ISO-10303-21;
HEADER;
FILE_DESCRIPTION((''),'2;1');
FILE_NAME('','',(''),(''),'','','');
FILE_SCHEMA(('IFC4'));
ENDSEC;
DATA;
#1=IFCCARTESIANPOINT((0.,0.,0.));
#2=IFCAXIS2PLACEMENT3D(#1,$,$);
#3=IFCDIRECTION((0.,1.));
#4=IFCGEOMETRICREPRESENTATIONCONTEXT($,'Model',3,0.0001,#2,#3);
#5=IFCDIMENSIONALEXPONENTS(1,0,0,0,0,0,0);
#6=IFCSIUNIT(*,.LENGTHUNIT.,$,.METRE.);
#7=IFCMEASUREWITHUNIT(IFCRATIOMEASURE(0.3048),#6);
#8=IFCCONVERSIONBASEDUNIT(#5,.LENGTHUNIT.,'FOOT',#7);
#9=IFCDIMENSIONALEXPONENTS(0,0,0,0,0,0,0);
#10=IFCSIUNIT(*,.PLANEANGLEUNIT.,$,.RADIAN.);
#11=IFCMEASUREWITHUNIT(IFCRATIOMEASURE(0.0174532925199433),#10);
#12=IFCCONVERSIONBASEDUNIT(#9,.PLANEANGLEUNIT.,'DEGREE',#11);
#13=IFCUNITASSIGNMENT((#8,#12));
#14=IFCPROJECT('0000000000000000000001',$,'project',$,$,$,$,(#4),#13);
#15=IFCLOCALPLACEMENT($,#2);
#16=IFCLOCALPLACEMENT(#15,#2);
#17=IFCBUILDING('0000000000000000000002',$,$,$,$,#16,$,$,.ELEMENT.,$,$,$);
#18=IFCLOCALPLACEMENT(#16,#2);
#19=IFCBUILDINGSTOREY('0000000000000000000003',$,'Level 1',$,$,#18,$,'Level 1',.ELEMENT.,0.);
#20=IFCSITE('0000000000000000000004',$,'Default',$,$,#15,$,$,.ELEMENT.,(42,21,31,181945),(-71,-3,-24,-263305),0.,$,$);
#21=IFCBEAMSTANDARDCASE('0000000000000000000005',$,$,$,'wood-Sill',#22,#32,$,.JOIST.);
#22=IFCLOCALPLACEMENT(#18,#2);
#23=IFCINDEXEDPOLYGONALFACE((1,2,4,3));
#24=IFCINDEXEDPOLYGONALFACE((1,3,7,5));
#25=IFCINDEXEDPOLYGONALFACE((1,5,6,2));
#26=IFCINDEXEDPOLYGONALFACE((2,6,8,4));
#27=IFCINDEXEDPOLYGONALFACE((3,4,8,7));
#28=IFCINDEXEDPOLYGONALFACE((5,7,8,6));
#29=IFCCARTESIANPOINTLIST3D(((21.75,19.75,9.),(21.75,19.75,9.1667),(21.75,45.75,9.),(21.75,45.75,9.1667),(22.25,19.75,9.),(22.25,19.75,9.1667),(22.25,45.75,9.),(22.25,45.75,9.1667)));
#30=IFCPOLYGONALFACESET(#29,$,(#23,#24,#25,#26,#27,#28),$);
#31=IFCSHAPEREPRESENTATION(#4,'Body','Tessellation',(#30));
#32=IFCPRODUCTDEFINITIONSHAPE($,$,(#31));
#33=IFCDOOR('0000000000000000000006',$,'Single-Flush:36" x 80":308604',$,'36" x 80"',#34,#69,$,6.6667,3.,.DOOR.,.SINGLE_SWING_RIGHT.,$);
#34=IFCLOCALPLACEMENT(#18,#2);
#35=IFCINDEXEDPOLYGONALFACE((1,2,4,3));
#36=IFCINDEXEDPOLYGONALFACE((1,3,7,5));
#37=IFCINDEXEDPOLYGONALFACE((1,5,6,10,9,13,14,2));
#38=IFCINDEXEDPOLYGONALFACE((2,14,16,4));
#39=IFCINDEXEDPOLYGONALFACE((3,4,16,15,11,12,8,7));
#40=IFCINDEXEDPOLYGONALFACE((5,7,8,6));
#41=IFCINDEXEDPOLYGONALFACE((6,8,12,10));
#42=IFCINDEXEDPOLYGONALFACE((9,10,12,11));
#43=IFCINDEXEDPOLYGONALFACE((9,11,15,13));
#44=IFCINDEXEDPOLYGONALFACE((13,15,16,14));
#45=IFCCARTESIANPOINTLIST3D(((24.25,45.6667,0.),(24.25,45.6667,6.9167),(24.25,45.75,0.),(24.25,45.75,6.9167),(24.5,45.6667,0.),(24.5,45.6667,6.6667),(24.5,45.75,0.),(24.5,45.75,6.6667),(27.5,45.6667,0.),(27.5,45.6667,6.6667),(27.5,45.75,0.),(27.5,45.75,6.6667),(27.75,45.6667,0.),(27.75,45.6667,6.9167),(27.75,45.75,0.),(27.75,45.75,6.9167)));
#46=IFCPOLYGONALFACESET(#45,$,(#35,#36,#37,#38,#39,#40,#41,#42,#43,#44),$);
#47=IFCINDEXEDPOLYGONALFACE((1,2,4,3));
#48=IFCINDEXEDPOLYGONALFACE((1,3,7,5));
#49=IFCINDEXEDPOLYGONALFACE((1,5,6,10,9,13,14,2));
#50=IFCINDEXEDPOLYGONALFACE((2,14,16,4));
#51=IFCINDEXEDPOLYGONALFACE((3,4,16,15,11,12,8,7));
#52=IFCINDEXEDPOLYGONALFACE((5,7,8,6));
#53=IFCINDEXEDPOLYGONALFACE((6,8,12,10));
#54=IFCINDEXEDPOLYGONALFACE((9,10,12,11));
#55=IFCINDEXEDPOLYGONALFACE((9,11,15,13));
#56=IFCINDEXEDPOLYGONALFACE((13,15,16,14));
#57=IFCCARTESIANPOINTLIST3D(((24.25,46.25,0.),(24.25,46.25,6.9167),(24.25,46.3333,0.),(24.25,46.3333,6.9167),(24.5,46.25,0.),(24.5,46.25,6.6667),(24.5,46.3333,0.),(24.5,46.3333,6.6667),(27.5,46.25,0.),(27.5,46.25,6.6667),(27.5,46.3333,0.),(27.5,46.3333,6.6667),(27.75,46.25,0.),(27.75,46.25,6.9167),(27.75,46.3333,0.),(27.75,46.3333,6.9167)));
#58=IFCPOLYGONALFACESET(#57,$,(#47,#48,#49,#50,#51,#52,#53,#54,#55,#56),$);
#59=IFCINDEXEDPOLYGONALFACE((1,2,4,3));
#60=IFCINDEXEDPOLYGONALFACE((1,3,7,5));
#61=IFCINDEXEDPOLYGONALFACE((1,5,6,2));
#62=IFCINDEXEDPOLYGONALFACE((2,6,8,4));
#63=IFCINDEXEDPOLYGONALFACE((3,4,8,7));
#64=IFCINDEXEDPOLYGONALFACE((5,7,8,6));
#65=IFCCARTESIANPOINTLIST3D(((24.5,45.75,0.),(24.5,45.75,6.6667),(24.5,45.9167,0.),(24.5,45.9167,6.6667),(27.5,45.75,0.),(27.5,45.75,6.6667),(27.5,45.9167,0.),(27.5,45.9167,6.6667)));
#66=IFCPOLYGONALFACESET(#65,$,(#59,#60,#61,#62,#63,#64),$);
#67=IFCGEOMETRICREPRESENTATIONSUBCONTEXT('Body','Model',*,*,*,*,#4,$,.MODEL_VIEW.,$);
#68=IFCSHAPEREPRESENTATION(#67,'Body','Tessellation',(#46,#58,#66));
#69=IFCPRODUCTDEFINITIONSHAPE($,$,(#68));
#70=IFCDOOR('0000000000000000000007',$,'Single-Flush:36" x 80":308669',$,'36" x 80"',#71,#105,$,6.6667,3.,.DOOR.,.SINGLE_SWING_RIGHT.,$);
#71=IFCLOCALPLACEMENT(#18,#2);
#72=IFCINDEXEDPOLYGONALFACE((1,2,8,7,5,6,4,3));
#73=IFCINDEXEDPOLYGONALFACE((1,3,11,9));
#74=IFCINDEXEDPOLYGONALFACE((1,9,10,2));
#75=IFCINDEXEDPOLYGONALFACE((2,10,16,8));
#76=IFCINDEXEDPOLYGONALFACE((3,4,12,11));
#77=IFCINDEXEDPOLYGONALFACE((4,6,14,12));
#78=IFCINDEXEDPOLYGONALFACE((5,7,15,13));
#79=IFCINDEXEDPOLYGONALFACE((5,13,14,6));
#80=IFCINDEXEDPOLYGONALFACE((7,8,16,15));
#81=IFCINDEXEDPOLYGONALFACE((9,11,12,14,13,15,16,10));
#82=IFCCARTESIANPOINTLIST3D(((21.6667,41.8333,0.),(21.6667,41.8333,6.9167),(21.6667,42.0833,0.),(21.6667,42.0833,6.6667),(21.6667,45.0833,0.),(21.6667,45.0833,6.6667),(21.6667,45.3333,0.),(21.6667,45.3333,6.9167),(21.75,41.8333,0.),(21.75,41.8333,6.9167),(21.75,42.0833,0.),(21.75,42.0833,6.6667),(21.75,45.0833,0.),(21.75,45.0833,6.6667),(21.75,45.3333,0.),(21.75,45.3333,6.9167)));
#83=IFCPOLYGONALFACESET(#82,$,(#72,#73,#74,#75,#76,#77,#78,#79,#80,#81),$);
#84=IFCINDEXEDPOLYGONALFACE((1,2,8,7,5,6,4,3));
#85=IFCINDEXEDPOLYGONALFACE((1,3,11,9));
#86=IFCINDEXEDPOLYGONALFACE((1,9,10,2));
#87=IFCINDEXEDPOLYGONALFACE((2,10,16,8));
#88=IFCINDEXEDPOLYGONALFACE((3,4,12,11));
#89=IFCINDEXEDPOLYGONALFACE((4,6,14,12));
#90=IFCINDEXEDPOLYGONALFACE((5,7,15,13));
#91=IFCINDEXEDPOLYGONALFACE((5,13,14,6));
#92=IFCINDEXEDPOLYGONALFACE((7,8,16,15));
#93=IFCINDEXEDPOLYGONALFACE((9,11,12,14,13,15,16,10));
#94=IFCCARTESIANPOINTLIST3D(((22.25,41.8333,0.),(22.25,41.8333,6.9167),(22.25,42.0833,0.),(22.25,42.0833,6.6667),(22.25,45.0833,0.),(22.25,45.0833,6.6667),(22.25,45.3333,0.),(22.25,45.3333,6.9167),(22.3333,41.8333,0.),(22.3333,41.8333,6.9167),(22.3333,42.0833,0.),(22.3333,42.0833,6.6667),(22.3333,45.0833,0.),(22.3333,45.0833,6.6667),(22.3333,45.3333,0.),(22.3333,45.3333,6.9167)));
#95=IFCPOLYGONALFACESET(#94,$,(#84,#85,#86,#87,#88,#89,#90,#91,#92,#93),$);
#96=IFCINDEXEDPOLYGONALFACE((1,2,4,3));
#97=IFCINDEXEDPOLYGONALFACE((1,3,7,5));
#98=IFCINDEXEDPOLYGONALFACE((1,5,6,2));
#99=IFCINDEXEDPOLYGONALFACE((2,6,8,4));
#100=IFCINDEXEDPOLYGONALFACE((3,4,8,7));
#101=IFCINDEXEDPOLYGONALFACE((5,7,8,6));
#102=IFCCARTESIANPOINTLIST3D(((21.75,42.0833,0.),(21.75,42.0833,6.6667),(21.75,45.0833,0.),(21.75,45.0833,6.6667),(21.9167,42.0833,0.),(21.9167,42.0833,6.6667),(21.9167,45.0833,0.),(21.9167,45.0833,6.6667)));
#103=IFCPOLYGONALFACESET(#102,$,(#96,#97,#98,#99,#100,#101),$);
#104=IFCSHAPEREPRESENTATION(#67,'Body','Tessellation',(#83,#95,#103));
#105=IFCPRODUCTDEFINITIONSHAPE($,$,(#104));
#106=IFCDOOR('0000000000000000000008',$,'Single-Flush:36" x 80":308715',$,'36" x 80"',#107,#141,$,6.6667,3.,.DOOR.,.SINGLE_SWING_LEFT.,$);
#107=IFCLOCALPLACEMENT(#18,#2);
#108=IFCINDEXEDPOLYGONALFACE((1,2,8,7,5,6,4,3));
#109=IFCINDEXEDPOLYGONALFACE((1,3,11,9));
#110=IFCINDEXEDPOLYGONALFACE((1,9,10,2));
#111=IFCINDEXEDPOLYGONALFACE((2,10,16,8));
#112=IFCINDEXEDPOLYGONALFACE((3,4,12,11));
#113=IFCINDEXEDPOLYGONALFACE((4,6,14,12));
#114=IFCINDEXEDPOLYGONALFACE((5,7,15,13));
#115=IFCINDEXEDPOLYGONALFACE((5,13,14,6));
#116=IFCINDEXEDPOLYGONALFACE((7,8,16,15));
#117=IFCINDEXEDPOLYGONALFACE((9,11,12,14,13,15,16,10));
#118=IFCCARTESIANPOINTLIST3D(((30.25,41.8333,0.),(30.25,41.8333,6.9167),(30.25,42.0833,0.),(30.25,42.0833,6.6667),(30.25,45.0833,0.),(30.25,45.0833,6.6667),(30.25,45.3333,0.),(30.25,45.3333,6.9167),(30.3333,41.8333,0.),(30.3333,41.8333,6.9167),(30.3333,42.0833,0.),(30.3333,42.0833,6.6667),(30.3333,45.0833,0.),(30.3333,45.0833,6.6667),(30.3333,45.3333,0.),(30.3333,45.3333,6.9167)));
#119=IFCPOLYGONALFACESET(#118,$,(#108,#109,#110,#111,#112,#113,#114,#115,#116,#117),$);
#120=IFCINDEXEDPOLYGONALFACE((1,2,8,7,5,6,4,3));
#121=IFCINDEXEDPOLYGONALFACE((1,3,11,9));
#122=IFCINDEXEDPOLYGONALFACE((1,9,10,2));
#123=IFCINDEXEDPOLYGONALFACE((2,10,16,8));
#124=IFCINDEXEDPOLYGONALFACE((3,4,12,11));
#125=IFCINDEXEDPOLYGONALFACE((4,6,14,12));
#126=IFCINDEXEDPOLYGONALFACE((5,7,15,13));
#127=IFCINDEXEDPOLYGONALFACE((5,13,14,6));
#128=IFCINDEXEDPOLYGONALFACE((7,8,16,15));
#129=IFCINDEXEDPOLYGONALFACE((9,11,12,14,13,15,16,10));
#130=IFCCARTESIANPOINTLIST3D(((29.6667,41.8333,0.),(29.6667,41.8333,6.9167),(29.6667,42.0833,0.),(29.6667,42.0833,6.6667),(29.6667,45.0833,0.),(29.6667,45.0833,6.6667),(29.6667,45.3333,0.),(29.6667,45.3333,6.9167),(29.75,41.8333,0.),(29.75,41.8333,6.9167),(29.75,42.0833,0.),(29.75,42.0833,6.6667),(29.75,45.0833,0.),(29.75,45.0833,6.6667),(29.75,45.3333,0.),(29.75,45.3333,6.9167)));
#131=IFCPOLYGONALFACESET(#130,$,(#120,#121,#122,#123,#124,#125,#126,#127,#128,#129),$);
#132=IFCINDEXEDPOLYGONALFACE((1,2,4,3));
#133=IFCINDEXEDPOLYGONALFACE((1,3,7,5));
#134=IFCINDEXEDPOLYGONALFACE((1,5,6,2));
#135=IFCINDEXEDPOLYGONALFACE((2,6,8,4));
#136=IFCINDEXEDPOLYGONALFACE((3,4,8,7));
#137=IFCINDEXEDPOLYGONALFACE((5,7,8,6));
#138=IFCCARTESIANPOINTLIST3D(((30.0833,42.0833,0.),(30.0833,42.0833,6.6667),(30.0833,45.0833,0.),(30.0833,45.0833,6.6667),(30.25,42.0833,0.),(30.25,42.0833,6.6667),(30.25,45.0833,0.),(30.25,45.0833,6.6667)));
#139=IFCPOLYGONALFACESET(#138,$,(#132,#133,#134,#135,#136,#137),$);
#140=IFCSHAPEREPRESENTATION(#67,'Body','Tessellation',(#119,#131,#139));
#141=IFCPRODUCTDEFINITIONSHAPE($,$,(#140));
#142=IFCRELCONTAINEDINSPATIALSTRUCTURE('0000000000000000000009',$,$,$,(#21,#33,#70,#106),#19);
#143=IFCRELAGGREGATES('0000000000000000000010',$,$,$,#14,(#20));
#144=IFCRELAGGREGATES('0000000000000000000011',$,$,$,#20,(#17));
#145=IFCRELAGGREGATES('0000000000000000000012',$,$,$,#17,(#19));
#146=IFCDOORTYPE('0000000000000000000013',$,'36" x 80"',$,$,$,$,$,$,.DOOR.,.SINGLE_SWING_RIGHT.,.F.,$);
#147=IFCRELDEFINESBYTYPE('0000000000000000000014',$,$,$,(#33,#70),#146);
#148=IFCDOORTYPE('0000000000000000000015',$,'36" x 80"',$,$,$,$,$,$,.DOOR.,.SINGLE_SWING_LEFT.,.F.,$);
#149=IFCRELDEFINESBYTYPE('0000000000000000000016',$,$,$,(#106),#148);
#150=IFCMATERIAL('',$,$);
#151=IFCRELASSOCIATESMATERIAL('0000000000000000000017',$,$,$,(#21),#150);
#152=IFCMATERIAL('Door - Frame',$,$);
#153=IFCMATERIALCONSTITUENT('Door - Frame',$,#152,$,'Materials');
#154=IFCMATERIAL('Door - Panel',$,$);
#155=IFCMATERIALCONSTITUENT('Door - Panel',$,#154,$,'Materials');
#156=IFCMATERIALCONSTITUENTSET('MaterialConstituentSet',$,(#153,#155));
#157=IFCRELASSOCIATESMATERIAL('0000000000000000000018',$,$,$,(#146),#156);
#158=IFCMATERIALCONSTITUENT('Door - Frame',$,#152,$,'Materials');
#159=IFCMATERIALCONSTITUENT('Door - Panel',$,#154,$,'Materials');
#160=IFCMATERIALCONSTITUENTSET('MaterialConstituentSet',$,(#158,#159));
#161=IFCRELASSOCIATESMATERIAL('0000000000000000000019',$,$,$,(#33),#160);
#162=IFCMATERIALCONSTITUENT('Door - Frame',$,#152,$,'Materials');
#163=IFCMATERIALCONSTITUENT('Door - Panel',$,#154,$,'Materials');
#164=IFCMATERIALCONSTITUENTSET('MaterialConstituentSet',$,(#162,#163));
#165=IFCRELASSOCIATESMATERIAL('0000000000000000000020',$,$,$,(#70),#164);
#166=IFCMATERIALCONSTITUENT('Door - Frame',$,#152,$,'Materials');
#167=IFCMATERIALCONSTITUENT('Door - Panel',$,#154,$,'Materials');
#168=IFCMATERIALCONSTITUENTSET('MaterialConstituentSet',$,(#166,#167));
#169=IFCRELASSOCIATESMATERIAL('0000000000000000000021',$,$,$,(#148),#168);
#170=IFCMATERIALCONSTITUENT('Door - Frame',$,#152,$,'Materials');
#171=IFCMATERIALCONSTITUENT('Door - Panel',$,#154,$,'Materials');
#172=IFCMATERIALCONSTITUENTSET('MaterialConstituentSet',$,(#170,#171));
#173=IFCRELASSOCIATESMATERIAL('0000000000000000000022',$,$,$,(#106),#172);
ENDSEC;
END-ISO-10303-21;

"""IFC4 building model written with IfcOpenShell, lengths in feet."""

from ifc_helpers import new_model, entity, si_unit, converted_unit, direction, frame, origin, origin_with_axes, origin_2d_with_axis, place, context, subcontext, project, spatial, polyline, rectangle, outline, extrude, source, transform, mapped, material, constituent, constituent_set, type_object, type_shapes, element, save


model = new_model("IFC4")

# Units and contexts
model_context = context("Model", 3, precision=0.0001, world=origin(), true_north=direction((0.0, 1.0)))
body_context = subcontext(model_context, "Body", "Model", "MODEL_VIEW")
ifc_project = project(units=[converted_unit("LENGTHUNIT", "FOOT", entity("IfcRatioMeasure", 0.3048), si_unit("LENGTHUNIT", "METRE"), dimensions=[1, 0, 0, 0, 0, 0, 0]), converted_unit("PLANEANGLEUNIT", "DEGREE", entity("IfcRatioMeasure", 0.0174532925199433), si_unit("PLANEANGLEUNIT", "RADIAN"), dimensions=[0, 0, 0, 0, 0, 0, 0])], contexts=[model_context])

# Site, building, storey
site_placement = place(None, origin())
site = spatial("IfcSite", under=ifc_project, at=site_placement, Name="Default", CompositionType="ELEMENT", RefLatitude=(42, 21, 31, 181945), RefLongitude=(-71, -3, -24, -263305), RefElevation=0.0)
building_placement = place(site_placement, origin())
building = spatial("IfcBuilding", under=site, at=building_placement, CompositionType="ELEMENT")
storey_placement = place(building_placement, origin())
storey = spatial("IfcBuildingStorey", under=building, at=storey_placement, Name="Level 1", LongName="Level 1", CompositionType="ELEMENT", Elevation=0.0)

# Shared definitions
placement_1 = place(storey_placement, frame((-0.25, 46.0, 0.0)))
placement_2 = place(storey_placement, frame((22.0, 45.75, 0.0), z_axis=(0.0, 0.0, 1.0), x_axis=(0.0, -1.0, 0.0)))

# Beam
placement_3 = place(storey_placement, frame((30.0, 45.75, 0.0), z_axis=(0.0, 0.0, 1.0), x_axis=(0.0, -1.0, 0.0)))
ifc_material_1 = material(Name="")
for number, where, z_axis, x_axis in (
    (1, (0.0, 0.0, 9.0834), (1.0, 0.0, 0.0), (0.0, 0.0, 1.0)),
):
    element("IfcBeamStandardCase", number, at=place(placement_2, frame(where, z_axis=z_axis, x_axis=x_axis)), inside=storey, material=ifc_material_1, ObjectType="wood-Sill", PredefinedType="JOIST", context=model_context, shape_type="SweptSolid", body=[
        extrude(rectangle(XDim=0.1667, YDim=0.5), origin_with_axes(), (0.0, 0.0, 1.0), 26.0),
    ])

# Doors
ifc_material_2 = material(Name="Door - Frame")
ifc_constituent_1 = constituent(ifc_material_2, Name="Door - Frame", Category="Materials")
ifc_material_3 = material(Name="Door - Panel")
ifc_constituent_2 = constituent(ifc_material_3, Name="Door - Panel", Category="Materials")
ifc_constituent_set_1 = constituent_set(constituents=[ifc_constituent_1, ifc_constituent_2], Name="MaterialConstituentSet")
ifc_constituent_3 = constituent(ifc_material_2, Name="Door - Frame", Category="Materials")
ifc_constituent_4 = constituent(ifc_material_3, Name="Door - Panel", Category="Materials")
ifc_constituent_set_2 = constituent_set(constituents=[ifc_constituent_3, ifc_constituent_4], Name="MaterialConstituentSet")
door_type_1 = type_object("IfcDoorType", Name="36\" x 80\"", OperationType="SINGLE_SWING_RIGHT", ParameterTakesPrecedence=False, PredefinedType="DOOR", material=ifc_constituent_set_2)
shared_shape_1 = source(origin(), body_context, "Body", "SweptSolid", [
    extrude(outline(polyline([(-1.75, -3.5208), (1.75, -3.5208), (1.75, 3.3958), (1.5, 3.3958), (1.5, -3.2708), (-1.5, -3.2708), (-1.5, 3.3958), (-1.75, 3.3958), (-1.75, -3.5208)])), frame((1.5, 0.5, 3.3958), z_axis=(0.0, 1.0, 0.0), x_axis=(1.0, 0.0, 0.0)), (0.0, 0.0, 1.0), 0.0833),
    extrude(outline(polyline([(-3.5208, -1.75), (3.3958, -1.75), (3.3958, -1.5), (-3.2708, -1.5), (-3.2708, 1.5), (3.3958, 1.5), (3.3958, 1.75), (-3.5208, 1.75), (-3.5208, -1.75)])), frame((1.5, -0.0833, 3.3958), z_axis=(0.0, 1.0, 0.0), x_axis=(0.0, 0.0, -1.0)), (0.0, 0.0, 1.0), 0.0833),
    extrude(rectangle(XDim=0.1667, YDim=3.0, at=origin_2d_with_axis()), frame((1.5, 0.4167, 0.0), z_axis=(0.0, 0.0, 1.0), x_axis=(0.0, 1.0, 0.0)), (0.0, 0.0, 1.0), 6.6667),
])
type_shapes(door_type_1, [shared_shape_1])
placement_4 = place(placement_1, frame((27.75, 0.25, 0.0)))
door_1_placement = place(placement_4, frame((0.0, 0.0, 0.0), z_axis=(0.0, 0.0, 1.0), x_axis=(-1.0, 0.0, 0.0)))
element("IfcDoor", 2, at=door_1_placement, inside=storey, type_object=door_type_1, material=ifc_constituent_set_1, Name="Single-Flush:36\" x 80\":308604", ObjectType="36\" x 80\"", OperationType="SINGLE_SWING_RIGHT", OverallHeight=6.6667, OverallWidth=3.0, PredefinedType="DOOR", context=body_context, shape_type="MappedRepresentation", body=[
    mapped(shared_shape_1, transform((0.0, 0.0, 0.0), scale=1.0)),
])
ifc_constituent_5 = constituent(ifc_material_2, Name="Door - Frame", Category="Materials")
ifc_constituent_6 = constituent(ifc_material_3, Name="Door - Panel", Category="Materials")
ifc_constituent_set_3 = constituent_set(constituents=[ifc_constituent_5, ifc_constituent_6], Name="MaterialConstituentSet")
placement_5 = place(placement_2, frame((3.6667, 0.25, 0.0)))
door_2_placement = place(placement_5, frame((0.0, 0.0, 0.0), z_axis=(0.0, 0.0, 1.0), x_axis=(-1.0, 0.0, 0.0)))
element("IfcDoor", 3, at=door_2_placement, inside=storey, type_object=door_type_1, material=ifc_constituent_set_3, Name="Single-Flush:36\" x 80\":308669", ObjectType="36\" x 80\"", OperationType="SINGLE_SWING_RIGHT", OverallHeight=6.6667, OverallWidth=3.0, PredefinedType="DOOR", context=body_context, shape_type="MappedRepresentation", body=[
    mapped(shared_shape_1, transform((0.0, 0.0, 0.0), scale=1.0)),
])
ifc_constituent_7 = constituent(ifc_material_2, Name="Door - Frame", Category="Materials")
ifc_constituent_8 = constituent(ifc_material_3, Name="Door - Panel", Category="Materials")
ifc_constituent_set_4 = constituent_set(constituents=[ifc_constituent_7, ifc_constituent_8], Name="MaterialConstituentSet")
ifc_constituent_9 = constituent(ifc_material_2, Name="Door - Frame", Category="Materials")
ifc_constituent_10 = constituent(ifc_material_3, Name="Door - Panel", Category="Materials")
ifc_constituent_set_5 = constituent_set(constituents=[ifc_constituent_9, ifc_constituent_10], Name="MaterialConstituentSet")
door_type_2 = type_object("IfcDoorType", Name="36\" x 80\"", OperationType="SINGLE_SWING_LEFT", ParameterTakesPrecedence=False, PredefinedType="DOOR", material=ifc_constituent_set_5)
shared_shape_2 = source(origin(), body_context, "Body", "SweptSolid", [
    extrude(outline(polyline([(-1.75, -3.5208), (1.75, -3.5208), (1.75, 3.3958), (1.5, 3.3958), (1.5, -3.2708), (-1.5, -3.2708), (-1.5, 3.3958), (-1.75, 3.3958), (-1.75, -3.5208)])), frame((1.5, 0.5833, 3.3958), z_axis=(0.0, -1.0, 0.0), x_axis=(-1.0, 0.0, 0.0)), (0.0, 0.0, 1.0), 0.0833),
    extrude(outline(polyline([(-3.5208, -1.75), (3.3958, -1.75), (3.3958, -1.5), (-3.2708, -1.5), (-3.2708, 1.5), (3.3958, 1.5), (3.3958, 1.75), (-3.5208, 1.75), (-3.5208, -1.75)])), frame((1.5, 0.0, 3.3958), z_axis=(0.0, -1.0, 0.0), x_axis=(0.0, 0.0, -1.0)), (0.0, 0.0, 1.0), 0.0833),
    extrude(rectangle(XDim=3.0, YDim=0.1667, at=origin_2d_with_axis()), frame((1.5, 0.4167, 0.0)), (0.0, 0.0, 1.0), 6.6667),
])
type_shapes(door_type_2, [shared_shape_2])
placement_6 = place(placement_3, frame((0.6667, -0.25, 0.0)))
door_3_placement = place(placement_6, origin())
element("IfcDoor", 4, at=door_3_placement, inside=storey, type_object=door_type_2, material=ifc_constituent_set_4, Name="Single-Flush:36\" x 80\":308715", ObjectType="36\" x 80\"", OperationType="SINGLE_SWING_LEFT", OverallHeight=6.6667, OverallWidth=3.0, PredefinedType="DOOR", context=body_context, shape_type="MappedRepresentation", body=[
    mapped(shared_shape_2, transform((0.0, 0.0, 0.0), scale=1.0)),
])

save(model, "model.ifc")
